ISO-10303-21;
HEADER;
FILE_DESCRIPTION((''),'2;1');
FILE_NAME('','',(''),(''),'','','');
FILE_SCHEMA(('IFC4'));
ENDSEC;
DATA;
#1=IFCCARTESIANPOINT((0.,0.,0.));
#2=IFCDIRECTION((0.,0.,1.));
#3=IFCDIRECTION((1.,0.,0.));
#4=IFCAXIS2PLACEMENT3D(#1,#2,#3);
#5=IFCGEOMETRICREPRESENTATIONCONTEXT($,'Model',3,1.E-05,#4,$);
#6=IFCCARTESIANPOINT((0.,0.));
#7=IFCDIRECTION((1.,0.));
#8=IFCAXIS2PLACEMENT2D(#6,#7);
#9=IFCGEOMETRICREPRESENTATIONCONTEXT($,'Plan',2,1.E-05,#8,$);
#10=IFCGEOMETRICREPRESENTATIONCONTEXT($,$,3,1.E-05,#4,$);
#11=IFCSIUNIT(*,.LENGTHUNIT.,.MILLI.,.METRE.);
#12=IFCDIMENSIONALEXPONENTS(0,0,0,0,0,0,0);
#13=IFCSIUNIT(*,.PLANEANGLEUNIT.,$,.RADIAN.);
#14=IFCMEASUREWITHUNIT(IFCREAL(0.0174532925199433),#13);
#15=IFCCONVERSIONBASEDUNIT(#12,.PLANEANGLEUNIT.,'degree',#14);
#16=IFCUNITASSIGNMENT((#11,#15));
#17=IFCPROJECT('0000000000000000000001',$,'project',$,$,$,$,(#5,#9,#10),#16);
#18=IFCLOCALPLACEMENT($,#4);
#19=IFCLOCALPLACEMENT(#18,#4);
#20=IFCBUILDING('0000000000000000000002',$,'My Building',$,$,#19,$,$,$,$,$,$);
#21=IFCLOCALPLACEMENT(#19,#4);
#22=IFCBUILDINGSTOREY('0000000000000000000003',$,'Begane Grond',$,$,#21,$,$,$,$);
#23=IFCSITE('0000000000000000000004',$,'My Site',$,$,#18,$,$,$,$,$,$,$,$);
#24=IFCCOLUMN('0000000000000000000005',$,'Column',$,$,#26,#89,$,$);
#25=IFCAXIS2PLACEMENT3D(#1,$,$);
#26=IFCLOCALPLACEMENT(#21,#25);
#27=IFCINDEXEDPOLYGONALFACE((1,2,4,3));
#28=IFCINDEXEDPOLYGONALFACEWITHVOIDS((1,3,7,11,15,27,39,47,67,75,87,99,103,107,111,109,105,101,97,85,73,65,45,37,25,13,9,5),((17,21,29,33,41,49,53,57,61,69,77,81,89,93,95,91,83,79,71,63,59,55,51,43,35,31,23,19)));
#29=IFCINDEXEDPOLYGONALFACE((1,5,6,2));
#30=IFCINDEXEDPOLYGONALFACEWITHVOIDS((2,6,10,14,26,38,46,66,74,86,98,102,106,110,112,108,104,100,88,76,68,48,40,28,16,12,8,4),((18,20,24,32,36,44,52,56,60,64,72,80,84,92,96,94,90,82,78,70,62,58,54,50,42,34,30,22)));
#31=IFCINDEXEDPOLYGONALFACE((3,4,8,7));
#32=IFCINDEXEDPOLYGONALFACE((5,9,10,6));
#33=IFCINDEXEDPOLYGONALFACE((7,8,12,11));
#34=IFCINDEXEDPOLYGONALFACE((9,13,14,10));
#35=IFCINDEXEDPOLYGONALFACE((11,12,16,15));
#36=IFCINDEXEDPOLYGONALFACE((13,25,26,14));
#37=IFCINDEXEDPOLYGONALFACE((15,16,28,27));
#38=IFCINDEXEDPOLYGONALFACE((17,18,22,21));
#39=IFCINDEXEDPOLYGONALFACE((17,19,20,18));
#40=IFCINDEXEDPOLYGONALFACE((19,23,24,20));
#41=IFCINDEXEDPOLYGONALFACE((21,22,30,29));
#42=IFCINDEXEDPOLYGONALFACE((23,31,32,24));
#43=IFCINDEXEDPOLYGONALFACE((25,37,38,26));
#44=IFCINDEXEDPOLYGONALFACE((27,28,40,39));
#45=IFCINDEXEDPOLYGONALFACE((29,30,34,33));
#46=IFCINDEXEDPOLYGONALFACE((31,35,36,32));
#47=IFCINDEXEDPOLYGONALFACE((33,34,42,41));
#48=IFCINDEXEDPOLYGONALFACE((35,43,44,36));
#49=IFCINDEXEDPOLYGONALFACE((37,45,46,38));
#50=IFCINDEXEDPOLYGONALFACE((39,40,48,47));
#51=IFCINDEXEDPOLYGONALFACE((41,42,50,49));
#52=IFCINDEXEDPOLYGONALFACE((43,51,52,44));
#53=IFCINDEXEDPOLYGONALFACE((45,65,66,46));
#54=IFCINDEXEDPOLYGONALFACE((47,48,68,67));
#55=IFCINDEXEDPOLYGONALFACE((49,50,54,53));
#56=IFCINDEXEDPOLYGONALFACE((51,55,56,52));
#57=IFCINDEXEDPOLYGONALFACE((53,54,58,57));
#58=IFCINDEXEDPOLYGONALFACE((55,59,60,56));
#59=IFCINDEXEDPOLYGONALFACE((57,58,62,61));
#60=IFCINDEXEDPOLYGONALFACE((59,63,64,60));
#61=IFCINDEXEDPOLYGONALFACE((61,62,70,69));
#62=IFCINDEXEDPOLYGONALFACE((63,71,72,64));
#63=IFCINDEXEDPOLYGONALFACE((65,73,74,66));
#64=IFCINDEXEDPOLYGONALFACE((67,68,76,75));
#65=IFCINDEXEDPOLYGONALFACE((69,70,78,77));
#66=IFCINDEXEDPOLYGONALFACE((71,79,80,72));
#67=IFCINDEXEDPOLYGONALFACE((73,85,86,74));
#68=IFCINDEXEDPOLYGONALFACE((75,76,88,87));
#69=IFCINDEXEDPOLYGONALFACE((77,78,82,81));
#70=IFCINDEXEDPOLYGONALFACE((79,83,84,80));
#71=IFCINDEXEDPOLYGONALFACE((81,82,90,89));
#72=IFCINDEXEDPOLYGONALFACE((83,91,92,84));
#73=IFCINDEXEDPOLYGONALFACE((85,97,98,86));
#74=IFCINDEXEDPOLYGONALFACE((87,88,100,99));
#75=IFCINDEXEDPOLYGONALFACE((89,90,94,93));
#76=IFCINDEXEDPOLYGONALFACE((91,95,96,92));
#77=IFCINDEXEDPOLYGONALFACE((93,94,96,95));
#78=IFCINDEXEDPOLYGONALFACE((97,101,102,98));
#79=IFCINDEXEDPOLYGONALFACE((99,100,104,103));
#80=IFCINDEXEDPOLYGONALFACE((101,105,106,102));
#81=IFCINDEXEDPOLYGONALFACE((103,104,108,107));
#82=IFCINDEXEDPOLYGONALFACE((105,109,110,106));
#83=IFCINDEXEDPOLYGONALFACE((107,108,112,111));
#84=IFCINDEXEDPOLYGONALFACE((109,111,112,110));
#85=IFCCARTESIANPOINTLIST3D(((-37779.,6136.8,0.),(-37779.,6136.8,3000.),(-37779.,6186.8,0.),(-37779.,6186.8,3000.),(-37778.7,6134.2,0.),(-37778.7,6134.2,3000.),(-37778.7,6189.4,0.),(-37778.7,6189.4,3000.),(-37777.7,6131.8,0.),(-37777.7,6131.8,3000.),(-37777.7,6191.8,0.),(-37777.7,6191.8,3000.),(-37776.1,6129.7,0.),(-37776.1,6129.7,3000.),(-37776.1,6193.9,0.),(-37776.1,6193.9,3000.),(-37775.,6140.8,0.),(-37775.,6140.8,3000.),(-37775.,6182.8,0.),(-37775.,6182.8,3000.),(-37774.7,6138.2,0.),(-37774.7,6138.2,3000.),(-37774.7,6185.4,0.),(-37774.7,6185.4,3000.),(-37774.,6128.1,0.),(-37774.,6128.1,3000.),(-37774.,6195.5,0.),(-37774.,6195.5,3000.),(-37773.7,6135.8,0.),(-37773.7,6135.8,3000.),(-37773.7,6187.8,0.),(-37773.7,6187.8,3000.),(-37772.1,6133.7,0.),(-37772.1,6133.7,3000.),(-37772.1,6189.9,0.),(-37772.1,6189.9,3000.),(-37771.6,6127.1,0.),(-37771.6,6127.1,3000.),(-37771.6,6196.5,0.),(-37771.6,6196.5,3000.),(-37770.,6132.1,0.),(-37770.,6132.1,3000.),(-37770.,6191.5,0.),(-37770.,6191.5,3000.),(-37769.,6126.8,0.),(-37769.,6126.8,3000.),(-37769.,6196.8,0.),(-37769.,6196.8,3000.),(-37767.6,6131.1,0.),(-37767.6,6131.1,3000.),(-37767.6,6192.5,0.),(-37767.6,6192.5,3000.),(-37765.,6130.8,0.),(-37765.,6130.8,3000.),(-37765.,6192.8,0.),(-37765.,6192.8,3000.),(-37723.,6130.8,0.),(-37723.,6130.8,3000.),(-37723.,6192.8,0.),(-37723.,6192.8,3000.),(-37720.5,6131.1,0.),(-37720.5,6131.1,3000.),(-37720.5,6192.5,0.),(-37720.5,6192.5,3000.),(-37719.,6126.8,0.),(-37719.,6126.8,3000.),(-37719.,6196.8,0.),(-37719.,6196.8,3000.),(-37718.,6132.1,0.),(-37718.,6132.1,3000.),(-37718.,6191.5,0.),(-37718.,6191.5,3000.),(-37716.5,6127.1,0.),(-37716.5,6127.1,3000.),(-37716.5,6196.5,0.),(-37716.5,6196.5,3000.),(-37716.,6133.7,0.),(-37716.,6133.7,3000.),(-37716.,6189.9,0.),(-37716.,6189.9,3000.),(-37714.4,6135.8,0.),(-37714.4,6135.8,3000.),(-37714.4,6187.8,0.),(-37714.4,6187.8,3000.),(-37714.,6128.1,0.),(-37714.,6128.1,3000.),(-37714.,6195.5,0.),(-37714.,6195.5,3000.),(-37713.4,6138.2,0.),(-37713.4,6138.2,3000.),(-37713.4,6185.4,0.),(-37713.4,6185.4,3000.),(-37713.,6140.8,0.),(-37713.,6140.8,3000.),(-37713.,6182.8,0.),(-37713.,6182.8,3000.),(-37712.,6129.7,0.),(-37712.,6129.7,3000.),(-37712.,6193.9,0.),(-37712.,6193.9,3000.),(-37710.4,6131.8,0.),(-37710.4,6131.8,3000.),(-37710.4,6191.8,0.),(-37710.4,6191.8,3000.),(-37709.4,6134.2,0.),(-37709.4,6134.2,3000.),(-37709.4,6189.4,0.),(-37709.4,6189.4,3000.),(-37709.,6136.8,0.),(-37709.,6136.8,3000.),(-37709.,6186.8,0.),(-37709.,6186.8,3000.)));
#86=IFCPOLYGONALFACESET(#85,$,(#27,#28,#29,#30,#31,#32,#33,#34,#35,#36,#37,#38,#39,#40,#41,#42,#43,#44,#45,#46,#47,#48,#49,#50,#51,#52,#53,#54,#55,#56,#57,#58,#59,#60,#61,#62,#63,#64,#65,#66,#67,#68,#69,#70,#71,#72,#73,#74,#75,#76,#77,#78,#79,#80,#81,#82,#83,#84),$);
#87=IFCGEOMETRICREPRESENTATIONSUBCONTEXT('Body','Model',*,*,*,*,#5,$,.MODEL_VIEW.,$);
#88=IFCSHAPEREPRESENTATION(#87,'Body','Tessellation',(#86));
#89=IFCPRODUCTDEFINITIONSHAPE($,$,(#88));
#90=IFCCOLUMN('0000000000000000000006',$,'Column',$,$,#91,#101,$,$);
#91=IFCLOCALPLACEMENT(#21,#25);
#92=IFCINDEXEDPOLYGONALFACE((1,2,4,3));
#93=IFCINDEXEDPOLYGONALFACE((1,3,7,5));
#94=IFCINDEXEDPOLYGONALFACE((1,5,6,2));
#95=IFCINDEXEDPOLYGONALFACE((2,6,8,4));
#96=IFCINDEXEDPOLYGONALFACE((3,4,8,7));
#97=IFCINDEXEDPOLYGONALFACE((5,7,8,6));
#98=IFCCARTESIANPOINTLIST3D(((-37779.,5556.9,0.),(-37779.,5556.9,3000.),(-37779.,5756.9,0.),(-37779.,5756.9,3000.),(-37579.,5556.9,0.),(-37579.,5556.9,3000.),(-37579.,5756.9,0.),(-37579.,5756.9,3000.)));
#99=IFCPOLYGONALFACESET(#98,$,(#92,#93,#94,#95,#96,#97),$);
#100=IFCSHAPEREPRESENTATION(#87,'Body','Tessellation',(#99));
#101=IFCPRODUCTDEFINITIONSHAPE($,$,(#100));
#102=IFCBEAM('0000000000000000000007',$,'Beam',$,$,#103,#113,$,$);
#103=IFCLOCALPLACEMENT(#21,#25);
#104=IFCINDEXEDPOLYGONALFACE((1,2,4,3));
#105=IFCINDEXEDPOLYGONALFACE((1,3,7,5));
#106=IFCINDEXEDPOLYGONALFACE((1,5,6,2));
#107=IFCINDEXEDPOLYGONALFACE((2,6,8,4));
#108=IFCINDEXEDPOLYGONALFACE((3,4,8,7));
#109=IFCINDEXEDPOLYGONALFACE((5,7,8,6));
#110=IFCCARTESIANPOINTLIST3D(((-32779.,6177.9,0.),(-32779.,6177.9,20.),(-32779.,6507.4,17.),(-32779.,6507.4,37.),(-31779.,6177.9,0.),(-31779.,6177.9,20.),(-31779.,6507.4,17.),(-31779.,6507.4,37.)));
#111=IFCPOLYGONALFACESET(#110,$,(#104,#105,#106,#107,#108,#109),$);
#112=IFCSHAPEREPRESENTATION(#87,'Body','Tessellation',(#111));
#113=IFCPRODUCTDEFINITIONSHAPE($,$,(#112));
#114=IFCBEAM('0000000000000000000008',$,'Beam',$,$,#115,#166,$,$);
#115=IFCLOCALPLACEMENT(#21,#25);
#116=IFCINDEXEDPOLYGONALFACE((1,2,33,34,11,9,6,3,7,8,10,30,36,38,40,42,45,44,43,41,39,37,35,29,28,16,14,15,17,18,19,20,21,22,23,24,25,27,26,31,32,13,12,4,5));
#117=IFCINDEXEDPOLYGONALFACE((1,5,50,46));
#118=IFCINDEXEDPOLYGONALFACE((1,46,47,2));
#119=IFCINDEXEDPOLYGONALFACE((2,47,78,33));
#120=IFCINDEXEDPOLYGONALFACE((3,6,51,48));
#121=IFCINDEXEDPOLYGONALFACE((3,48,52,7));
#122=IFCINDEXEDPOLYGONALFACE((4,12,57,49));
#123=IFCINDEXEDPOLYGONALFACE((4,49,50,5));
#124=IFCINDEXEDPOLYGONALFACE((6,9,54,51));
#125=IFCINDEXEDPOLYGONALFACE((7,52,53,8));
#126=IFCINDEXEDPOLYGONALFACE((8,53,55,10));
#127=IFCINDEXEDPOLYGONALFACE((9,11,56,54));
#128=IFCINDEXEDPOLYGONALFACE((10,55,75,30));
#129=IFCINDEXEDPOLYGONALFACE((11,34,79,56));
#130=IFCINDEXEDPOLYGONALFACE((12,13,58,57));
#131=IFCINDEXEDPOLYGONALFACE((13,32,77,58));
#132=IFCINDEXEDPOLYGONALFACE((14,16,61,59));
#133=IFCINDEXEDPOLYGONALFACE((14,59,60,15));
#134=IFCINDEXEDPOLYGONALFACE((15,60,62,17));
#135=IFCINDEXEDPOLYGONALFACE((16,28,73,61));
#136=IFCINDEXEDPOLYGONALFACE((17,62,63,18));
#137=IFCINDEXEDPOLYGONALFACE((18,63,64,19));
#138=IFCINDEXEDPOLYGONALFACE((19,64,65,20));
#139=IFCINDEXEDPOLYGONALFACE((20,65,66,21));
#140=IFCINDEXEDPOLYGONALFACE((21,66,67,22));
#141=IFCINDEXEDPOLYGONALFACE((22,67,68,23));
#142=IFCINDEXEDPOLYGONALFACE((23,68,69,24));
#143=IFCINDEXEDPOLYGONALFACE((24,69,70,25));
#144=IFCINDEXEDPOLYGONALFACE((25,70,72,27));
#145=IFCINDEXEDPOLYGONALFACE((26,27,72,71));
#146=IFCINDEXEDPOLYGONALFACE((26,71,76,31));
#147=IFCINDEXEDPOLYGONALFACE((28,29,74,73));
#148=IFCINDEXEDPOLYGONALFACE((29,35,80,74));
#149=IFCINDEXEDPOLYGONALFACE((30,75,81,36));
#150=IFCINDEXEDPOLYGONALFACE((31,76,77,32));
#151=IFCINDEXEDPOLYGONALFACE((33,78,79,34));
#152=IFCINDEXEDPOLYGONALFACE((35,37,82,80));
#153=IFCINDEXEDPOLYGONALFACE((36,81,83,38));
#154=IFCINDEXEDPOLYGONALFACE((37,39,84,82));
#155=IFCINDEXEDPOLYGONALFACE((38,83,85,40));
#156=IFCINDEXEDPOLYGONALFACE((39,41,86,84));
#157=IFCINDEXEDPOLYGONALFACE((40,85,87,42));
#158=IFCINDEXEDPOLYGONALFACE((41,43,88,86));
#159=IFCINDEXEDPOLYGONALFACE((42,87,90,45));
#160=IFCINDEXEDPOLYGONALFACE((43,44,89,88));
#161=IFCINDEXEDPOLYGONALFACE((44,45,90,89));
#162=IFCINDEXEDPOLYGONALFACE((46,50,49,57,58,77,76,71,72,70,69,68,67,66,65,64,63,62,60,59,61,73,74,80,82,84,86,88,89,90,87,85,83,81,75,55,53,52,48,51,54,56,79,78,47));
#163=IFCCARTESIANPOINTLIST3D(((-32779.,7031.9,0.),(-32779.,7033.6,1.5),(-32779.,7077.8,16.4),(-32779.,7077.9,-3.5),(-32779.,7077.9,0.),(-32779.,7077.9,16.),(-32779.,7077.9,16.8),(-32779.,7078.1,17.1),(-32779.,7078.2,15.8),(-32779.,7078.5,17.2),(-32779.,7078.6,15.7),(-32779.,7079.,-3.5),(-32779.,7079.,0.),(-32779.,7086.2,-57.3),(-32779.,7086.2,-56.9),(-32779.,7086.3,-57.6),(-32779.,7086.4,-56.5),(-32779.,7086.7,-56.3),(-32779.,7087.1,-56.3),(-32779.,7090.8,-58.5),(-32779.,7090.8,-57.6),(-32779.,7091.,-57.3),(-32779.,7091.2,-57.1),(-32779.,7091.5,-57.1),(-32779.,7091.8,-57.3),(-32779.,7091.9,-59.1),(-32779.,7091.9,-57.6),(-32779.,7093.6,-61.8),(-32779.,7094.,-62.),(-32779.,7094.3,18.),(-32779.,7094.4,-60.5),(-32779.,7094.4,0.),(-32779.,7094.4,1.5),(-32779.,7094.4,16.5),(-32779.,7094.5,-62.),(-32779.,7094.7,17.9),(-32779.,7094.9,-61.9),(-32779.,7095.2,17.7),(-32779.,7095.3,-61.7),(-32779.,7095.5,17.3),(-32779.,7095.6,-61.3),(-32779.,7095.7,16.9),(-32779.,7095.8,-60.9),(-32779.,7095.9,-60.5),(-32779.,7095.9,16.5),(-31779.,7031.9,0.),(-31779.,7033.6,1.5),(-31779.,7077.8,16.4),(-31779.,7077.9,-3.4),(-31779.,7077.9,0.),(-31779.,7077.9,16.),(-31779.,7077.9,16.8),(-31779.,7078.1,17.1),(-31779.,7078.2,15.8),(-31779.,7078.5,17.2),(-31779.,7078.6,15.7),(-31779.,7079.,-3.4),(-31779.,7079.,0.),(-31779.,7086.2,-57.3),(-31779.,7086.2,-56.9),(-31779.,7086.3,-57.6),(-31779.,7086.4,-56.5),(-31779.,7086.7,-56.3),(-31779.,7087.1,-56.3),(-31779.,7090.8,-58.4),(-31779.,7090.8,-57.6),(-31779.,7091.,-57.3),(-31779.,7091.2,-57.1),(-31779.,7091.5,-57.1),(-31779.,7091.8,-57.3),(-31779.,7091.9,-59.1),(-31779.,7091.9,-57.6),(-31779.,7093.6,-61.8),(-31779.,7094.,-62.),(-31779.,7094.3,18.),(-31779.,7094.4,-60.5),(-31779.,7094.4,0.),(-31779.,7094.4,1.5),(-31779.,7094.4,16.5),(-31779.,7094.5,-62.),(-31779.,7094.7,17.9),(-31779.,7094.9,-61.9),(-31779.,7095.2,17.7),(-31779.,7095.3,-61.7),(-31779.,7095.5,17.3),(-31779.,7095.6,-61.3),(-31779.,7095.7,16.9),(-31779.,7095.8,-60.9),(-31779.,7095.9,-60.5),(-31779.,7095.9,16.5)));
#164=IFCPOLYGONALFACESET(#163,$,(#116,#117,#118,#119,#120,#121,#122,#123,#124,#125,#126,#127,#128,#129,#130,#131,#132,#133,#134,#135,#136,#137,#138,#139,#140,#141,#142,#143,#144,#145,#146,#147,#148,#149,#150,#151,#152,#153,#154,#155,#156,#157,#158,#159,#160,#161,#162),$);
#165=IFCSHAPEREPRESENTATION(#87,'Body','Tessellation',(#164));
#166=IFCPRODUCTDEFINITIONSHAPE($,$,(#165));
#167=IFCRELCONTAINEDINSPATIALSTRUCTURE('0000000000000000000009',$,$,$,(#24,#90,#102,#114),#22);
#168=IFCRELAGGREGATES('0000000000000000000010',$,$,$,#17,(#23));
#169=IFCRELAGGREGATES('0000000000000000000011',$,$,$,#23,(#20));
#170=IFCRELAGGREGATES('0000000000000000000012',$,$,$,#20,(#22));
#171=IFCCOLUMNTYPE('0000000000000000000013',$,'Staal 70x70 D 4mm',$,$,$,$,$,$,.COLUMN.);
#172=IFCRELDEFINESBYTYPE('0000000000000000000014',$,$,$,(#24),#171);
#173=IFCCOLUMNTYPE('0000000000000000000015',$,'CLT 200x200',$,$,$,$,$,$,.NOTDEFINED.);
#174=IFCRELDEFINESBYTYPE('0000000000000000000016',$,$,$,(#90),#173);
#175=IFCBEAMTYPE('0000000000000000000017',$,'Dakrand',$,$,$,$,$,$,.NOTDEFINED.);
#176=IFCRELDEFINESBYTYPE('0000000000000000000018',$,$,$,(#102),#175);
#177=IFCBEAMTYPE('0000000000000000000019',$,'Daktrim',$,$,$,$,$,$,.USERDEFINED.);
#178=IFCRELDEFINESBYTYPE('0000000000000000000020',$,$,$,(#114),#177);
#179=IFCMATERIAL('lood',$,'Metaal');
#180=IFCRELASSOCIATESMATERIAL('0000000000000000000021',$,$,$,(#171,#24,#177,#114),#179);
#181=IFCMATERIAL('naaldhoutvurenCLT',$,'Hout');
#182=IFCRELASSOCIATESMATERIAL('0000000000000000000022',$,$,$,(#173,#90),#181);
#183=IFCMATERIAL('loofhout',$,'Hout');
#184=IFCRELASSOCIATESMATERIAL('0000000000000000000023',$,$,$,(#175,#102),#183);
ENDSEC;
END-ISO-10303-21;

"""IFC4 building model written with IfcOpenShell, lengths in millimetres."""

from ifc_helpers import new_model, entity, si_unit, converted_unit, frame, origin_with_axes, origin_2d_with_axis, place, context, subcontext, project, spatial, line, arc, indexed_curve, rectangle, hollow_rectangle, outline, extrude, material, material_profile, profile_set, profile_usage, type_object, element, save


model = new_model("IFC4")

# Units and contexts
model_context = context("Model", 3, precision=1e-05, world=origin_with_axes())
plan_context = context("Plan", 2, precision=1e-05, world=origin_2d_with_axis())
context_of_model = context(None, 3, precision=1e-05, world=origin_with_axes())
body_context = subcontext(model_context, "Body", "Model", "MODEL_VIEW")
ifc_project = project(units=[si_unit("LENGTHUNIT", "METRE", prefix="MILLI"), converted_unit("PLANEANGLEUNIT", "degree", entity("IfcReal", 0.0174532925199433), si_unit("PLANEANGLEUNIT", "RADIAN"), dimensions=[0, 0, 0, 0, 0, 0, 0])], contexts=[model_context, plan_context, context_of_model])

# Site, building, storey
site_placement = place(None, frame((0.0, 0.0, 0.0), z_axis=(0.0, 0.0, 1.0), x_axis=(1.0, 0.0, 0.0)))
site = spatial("IfcSite", under=ifc_project, at=site_placement, Name="My Site")
building_placement = place(site_placement, origin_with_axes())
building = spatial("IfcBuilding", under=site, at=building_placement, Name="My Building")
storey_placement = place(building_placement, origin_with_axes())
storey = spatial("IfcBuildingStorey", under=building, at=storey_placement, Name="Begane Grond")

# Columns
ifc_material_1 = material(Name="lood", Category="Metaal")
ifc_material_profile_1 = material_profile(ifc_material_1, hollow_rectangle(XDim=70.0, YDim=70.0, WallThickness=4.0, InnerFilletRadius=10.0, OuterFilletRadius=10.0))
ifc_profile_set_1 = profile_set([ifc_material_profile_1], Name="lood")
ifc_profile_usage_1 = profile_usage(ifc_profile_set_1, cardinal=5)
column_type_1 = type_object("IfcColumnType", Name="Staal 70x70 D 4mm", PredefinedType="COLUMN", material=ifc_profile_set_1)
column_1_placement = place(storey_placement, frame((-37744.0, 6161.8, 0.0), z_axis=(0.0, 0.0, 1.0), x_axis=(1.0, 0.0, 0.0)))
element("IfcColumn", 1, at=column_1_placement, inside=storey, type_object=column_type_1, material=ifc_profile_usage_1, Name="Column", context=body_context, shape_type="SweptSolid", body=[
    extrude(hollow_rectangle(XDim=70.0, YDim=70.0, WallThickness=4.0, InnerFilletRadius=10.0, OuterFilletRadius=10.0), origin_with_axes(), (0.0, 0.0, 1.0), 3000.0),
])
ifc_material_2 = material(Name="naaldhoutvurenCLT", Category="Hout")
ifc_material_profile_2 = material_profile(ifc_material_2, rectangle(XDim=200.0, YDim=200.0))
ifc_profile_set_2 = profile_set([ifc_material_profile_2], Name="naaldhoutvurenCLT")
ifc_profile_usage_2 = profile_usage(ifc_profile_set_2, cardinal=5)
column_type_2 = type_object("IfcColumnType", Name="CLT 200x200", PredefinedType="NOTDEFINED", material=ifc_profile_set_2)
column_2_placement = place(storey_placement, frame((-37679.0, 5656.9, 0.0), z_axis=(0.0, 0.0, 1.0), x_axis=(1.0, 0.0, 0.0)))
element("IfcColumn", 2, at=column_2_placement, inside=storey, type_object=column_type_2, material=ifc_profile_usage_2, Name="Column", context=body_context, shape_type="SweptSolid", body=[
    extrude(rectangle(XDim=200.0, YDim=200.0), origin_with_axes(), (0.0, 0.0, 1.0), 3000.0),
])

# Beams
ifc_material_3 = material(Name="loofhout", Category="Hout")
ifc_material_profile_3 = material_profile(ifc_material_3, outline(indexed_curve([(329.6, 37.0), (329.6, 17.0), (0.0, 0.0), (0.0, 20.0)], segments=[line(3, 2), line(2, 1), line(1, 4), line(4, 3)], self_intersect=False)))
ifc_profile_set_3 = profile_set([ifc_material_profile_3], Name="loofhout")
ifc_profile_usage_3 = profile_usage(ifc_profile_set_3)
beam_type_1 = type_object("IfcBeamType", Name="Dakrand", PredefinedType="NOTDEFINED", material=ifc_profile_set_3)
beam_1_placement = place(storey_placement, frame((-32779.0, 6177.9, 0.0), z_axis=(1.0, 0.0, 0.0), x_axis=(0.0, 1.0, 0.0)))
element("IfcBeam", 3, at=beam_1_placement, inside=storey, type_object=beam_type_1, material=ifc_profile_usage_3, Name="Beam", context=body_context, shape_type="SweptSolid", body=[
    extrude(outline(indexed_curve([(329.6, 37.0), (329.6, 17.0), (0.0, 0.0), (0.0, 20.0)], segments=[line(3, 2), line(2, 1), line(1, 4), line(4, 3)], self_intersect=False)), origin_with_axes(), (0.0, 0.0, 1.0), 1000.0),
])
ifc_material_profile_4 = material_profile(ifc_material_1, outline(indexed_curve([(12.9, -58.5), (12.9, -57.6), (13.5, -57.1), (14.1, -57.6), (14.1, -59.1), (16.5, -60.5), (16.5, 0.0), (1.1, 0.0), (1.1, -3.5), (0.0, -3.5), (0.0, 0.0), (-46.0, 0.0), (-44.3, 1.5), (16.5, 1.5), (16.5, 16.5), (0.7, 15.7), (-0.1, 16.4), (0.6, 17.2), (16.4, 18.0), (17.6, 17.3), (18.0, 16.5), (18.0, -60.5), (17.2, -61.8), (15.8, -61.8), (8.5, -57.6), (8.4, -56.7), (9.2, -56.3)], segments=[line(10, 9), line(9, 8), line(8, 7), line(7, 6), line(6, 5), line(5, 4), arc(4, 3, 2), line(2, 1), line(1, 27), arc(27, 26, 25), line(25, 24), arc(24, 23, 22), line(22, 21), arc(21, 20, 19), line(19, 18), arc(18, 17, 16), line(16, 15), line(15, 14), line(14, 13), line(13, 12), line(12, 11), line(11, 10)], self_intersect=False)))
ifc_profile_set_4 = profile_set([ifc_material_profile_4], Name="lood")
ifc_profile_usage_4 = profile_usage(ifc_profile_set_4, cardinal=5)
beam_type_2 = type_object("IfcBeamType", Name="Daktrim", PredefinedType="USERDEFINED", material=ifc_profile_set_4)
beam_2_placement = place(storey_placement, frame((-32779.0, 7077.9, 0.0), z_axis=(1.0, 0.0, 0.0), x_axis=(0.0, 1.0, 0.0)))
element("IfcBeam", 4, at=beam_2_placement, inside=storey, type_object=beam_type_2, material=ifc_profile_usage_4, Name="Beam", context=body_context, shape_type="SweptSolid", body=[
    extrude(outline(indexed_curve([(12.9, -58.5), (12.9, -57.6), (13.5, -57.1), (14.1, -57.6), (14.1, -59.1), (16.5, -60.5), (16.5, 0.0), (1.1, 0.0), (1.1, -3.5), (0.0, -3.5), (0.0, 0.0), (-46.0, 0.0), (-44.3, 1.5), (16.5, 1.5), (16.5, 16.5), (0.7, 15.7), (-0.1, 16.4), (0.6, 17.2), (16.4, 18.0), (17.6, 17.3), (18.0, 16.5), (18.0, -60.5), (17.2, -61.8), (15.8, -61.8), (8.5, -57.6), (8.4, -56.7), (9.2, -56.3)], segments=[line(10, 9), line(9, 8), line(8, 7), line(7, 6), line(6, 5), line(5, 4), arc(4, 3, 2), line(2, 1), line(1, 27), arc(27, 26, 25), line(25, 24), arc(24, 23, 22), line(22, 21), arc(21, 20, 19), line(19, 18), arc(18, 17, 16), line(16, 15), line(15, 14), line(14, 13), line(13, 12), line(12, 11), line(11, 10)], self_intersect=False)), origin_with_axes(), (0.0, 0.0, 1.0), 1000.0),
])

save(model, "model.ifc")
